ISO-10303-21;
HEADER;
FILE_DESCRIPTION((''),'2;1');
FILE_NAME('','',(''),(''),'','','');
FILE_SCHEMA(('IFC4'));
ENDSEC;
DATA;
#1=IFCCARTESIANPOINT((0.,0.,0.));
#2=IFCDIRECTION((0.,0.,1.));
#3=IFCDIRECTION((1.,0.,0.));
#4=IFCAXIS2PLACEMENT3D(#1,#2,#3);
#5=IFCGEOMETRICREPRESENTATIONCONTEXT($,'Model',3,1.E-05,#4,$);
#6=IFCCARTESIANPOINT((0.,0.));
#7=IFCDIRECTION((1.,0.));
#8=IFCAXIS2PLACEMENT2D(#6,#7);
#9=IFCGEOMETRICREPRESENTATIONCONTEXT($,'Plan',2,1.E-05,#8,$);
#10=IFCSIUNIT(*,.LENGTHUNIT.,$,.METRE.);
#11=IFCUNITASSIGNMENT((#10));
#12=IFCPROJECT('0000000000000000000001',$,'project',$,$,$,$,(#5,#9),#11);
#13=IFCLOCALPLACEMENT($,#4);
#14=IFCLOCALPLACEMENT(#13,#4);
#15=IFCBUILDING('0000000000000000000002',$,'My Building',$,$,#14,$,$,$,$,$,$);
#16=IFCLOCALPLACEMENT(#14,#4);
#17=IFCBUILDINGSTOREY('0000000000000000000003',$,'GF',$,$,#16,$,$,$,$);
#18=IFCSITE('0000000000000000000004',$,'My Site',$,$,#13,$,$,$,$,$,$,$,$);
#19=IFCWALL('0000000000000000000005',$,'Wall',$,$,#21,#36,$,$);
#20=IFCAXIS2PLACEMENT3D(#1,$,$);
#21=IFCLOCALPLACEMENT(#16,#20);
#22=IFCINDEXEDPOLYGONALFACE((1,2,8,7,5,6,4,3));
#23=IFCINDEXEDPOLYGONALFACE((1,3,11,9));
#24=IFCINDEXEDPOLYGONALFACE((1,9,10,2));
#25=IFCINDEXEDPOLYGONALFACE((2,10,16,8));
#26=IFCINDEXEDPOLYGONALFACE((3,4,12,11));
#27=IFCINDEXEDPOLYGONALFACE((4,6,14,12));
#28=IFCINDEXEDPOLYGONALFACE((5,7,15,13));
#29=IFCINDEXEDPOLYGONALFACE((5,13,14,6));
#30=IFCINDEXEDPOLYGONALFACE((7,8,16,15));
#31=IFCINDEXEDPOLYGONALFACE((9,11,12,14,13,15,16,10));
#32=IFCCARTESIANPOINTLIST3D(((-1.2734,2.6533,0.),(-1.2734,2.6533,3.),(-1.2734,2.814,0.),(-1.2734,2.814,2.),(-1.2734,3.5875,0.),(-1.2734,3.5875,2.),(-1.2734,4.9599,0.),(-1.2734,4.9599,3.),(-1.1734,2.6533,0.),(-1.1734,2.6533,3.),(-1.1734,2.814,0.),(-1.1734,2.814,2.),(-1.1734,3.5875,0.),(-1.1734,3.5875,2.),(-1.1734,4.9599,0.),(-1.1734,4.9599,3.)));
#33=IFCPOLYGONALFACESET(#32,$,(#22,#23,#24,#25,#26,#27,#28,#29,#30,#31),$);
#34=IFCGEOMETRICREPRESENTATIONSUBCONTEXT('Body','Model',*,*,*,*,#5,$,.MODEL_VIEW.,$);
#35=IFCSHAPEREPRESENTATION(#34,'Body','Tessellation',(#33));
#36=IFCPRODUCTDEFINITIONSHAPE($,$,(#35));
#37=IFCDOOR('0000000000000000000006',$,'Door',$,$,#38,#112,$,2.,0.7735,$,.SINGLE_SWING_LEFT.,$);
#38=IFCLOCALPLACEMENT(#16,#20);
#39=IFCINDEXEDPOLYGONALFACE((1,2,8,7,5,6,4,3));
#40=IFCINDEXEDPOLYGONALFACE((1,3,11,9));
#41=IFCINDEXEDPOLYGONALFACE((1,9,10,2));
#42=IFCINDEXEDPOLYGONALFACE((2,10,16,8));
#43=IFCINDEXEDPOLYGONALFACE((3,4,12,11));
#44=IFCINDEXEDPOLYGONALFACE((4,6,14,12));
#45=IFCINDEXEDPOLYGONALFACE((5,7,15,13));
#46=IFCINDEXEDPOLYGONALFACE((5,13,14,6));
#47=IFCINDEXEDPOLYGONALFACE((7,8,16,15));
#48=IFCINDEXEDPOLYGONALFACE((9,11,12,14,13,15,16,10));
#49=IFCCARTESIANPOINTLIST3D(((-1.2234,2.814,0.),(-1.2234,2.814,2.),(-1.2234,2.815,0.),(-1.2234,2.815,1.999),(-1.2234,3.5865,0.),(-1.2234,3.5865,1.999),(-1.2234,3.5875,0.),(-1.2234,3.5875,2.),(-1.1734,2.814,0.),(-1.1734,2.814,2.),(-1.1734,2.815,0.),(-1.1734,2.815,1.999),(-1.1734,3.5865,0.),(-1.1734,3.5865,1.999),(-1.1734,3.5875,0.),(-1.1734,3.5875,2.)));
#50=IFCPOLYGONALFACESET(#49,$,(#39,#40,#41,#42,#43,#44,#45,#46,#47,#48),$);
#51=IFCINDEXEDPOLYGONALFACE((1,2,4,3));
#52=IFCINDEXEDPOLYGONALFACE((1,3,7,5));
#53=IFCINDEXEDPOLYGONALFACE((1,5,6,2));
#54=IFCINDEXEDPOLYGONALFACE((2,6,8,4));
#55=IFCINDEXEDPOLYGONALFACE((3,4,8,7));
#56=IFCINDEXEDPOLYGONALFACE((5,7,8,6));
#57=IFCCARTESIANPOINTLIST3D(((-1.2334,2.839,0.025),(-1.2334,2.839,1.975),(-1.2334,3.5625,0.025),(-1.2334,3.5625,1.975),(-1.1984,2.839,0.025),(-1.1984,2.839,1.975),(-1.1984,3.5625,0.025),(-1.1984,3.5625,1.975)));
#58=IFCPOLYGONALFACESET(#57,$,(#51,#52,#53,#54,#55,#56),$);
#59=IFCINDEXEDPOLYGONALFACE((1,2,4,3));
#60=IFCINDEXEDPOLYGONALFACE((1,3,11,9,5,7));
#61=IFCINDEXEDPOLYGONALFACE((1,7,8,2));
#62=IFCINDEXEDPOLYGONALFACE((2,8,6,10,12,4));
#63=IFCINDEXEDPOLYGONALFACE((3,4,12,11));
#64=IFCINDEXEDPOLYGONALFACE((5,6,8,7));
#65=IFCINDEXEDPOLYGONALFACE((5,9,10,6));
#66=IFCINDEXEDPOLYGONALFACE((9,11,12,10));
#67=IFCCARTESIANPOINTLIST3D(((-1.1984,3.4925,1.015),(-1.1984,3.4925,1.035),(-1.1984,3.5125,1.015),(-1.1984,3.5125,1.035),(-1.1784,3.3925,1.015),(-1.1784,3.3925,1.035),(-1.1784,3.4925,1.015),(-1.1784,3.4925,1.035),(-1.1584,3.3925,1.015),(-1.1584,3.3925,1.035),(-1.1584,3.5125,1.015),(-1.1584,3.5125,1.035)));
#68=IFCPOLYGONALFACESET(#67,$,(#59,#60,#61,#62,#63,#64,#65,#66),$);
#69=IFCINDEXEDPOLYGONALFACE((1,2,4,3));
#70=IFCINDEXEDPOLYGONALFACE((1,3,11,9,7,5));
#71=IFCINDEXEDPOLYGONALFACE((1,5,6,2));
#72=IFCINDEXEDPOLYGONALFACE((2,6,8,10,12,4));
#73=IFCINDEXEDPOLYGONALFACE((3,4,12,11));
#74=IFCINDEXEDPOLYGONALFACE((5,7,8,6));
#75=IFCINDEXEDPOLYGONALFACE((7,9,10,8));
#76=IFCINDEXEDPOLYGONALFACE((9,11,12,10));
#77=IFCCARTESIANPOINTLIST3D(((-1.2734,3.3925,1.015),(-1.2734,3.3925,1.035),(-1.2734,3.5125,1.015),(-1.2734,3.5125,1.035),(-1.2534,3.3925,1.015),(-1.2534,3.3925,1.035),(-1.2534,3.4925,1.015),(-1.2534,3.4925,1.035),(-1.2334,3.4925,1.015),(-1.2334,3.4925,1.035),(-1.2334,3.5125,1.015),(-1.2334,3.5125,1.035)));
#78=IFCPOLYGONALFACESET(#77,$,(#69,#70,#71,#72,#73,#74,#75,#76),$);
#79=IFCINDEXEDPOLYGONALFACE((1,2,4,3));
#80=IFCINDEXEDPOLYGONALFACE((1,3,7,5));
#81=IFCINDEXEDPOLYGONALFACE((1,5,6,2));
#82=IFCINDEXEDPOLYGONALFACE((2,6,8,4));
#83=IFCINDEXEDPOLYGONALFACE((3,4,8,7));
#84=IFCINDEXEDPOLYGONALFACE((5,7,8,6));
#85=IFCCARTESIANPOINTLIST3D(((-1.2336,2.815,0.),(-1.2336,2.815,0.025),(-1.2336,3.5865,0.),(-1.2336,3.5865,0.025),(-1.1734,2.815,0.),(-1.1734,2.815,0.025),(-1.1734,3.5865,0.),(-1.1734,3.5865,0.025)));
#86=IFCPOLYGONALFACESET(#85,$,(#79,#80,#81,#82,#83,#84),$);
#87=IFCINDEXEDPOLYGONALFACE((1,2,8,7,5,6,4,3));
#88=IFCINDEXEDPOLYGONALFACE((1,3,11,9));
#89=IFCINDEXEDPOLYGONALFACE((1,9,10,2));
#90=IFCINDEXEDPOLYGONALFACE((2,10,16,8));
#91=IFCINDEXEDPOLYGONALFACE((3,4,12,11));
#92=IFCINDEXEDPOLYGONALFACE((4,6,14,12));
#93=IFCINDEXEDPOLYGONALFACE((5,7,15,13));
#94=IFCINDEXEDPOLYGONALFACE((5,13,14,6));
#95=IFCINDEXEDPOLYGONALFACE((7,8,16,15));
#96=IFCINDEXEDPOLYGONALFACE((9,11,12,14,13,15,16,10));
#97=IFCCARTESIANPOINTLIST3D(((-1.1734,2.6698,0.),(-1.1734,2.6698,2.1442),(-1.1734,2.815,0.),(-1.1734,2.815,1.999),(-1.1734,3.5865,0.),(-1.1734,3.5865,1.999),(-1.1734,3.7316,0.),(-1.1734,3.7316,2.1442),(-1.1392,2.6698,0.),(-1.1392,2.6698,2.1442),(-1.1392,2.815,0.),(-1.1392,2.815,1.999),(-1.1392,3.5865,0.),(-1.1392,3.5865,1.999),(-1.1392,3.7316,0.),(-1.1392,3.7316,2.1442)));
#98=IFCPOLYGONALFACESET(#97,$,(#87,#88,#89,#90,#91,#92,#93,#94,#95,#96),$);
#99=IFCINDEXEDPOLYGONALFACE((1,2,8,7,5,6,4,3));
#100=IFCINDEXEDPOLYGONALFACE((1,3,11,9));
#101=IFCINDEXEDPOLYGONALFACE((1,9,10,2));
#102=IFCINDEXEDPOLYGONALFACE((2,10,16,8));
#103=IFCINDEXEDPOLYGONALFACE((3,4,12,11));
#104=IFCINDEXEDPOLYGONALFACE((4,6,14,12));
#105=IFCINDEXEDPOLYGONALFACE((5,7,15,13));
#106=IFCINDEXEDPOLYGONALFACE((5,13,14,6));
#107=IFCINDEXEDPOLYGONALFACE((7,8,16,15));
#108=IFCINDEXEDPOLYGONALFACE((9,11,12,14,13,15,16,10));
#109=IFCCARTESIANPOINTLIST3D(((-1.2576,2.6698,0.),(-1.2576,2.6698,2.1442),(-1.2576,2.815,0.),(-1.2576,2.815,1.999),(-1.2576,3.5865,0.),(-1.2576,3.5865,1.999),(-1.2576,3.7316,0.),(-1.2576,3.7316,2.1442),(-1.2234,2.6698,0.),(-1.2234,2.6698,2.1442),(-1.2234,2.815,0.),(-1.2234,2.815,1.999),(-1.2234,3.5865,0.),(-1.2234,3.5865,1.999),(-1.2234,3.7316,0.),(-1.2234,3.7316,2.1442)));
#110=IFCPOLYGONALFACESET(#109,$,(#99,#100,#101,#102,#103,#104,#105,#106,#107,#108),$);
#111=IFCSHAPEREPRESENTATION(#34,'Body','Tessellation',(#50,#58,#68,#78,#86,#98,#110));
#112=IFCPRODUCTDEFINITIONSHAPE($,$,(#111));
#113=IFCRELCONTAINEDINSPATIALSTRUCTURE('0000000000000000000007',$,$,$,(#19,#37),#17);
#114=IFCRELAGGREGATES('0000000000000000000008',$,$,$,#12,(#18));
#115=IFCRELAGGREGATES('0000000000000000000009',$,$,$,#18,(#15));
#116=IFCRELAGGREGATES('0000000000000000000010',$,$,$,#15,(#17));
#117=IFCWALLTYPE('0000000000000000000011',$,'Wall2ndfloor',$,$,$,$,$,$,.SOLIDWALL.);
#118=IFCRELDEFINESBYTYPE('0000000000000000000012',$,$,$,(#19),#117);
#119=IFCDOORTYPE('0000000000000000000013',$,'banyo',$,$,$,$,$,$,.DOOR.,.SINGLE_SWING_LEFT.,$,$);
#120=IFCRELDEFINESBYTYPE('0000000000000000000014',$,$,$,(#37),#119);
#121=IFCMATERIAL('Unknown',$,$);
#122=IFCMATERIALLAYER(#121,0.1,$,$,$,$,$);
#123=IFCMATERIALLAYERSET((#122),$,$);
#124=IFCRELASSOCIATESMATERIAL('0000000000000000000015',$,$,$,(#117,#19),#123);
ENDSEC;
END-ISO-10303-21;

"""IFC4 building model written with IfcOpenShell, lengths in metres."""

from ifc_helpers import new_model, entity, si_unit, frame, origin_with_axes, origin_2d_with_axis, place, context, subcontext, project, spatial, line, indexed_curve, outline, extrude, shape, source, transform, mapped, material, layer, layer_set, layer_usage, type_object, type_shapes, element, fill, save


model = new_model("IFC4")

# Units and contexts
model_context = context("Model", 3, precision=1e-05, world=origin_with_axes())
plan_context = context("Plan", 2, precision=1e-05, world=origin_2d_with_axis())
body_context_1 = subcontext(model_context, "Body", "Model", "MODEL_VIEW")
body_context_2 = subcontext(plan_context, "Body", "Plan", "PLAN_VIEW")
ifc_project = project(units=[si_unit("LENGTHUNIT", "METRE")], contexts=[model_context, plan_context])

# Site, building, storey
site_placement = place(None, origin_with_axes())
site = spatial("IfcSite", under=ifc_project, at=site_placement, Name="My Site")
building_placement = place(site_placement, origin_with_axes())
building = spatial("IfcBuilding", under=site, at=building_placement, Name="My Building")
storey_placement = place(building_placement, origin_with_axes())
storey = spatial("IfcBuildingStorey", under=building, at=storey_placement, Name="GF")

# Shared definitions
ifc_material = material(Name="Unknown")

# Shared definitions
ifc_layer_1 = layer(ifc_material, 0.1)
ifc_layer_set_1 = layer_set([ifc_layer_1])
wall_type_1 = type_object("IfcWallType", Name="Wall2ndfloor", PredefinedType="SOLIDWALL", material=ifc_layer_set_1)

# Wall, opening, door
ifc_layer_usage_1 = layer_usage(ifc_layer_set_1, "AXIS2", "POSITIVE", 0.0)
wall_1_placement = place(storey_placement, frame((-1.1734, 2.6533, 0.0), z_axis=(0.0, 0.0, 1.0), x_axis=(0.0, 1.0, 0.0)))
wall_1 = element("IfcWall", 1, at=wall_1_placement, inside=storey, type_object=wall_type_1, material=ifc_layer_usage_1, Name="Wall", context=body_context_1, shape_type="SweptSolid", body=[
    extrude(outline(indexed_curve([(0.0, 0.0), (0.0, 0.1), (2.3066, 0.1), (2.3066, 0.0)], segments=[line(1, 2, 3, 4, 1)])), origin_with_axes(), (0.0, 0.0, 1.0), 3.0),
])
shared_shape_1 = source(origin_with_axes(), body_context_1, "Body", "SweptSolid", [
    extrude(outline(indexed_curve([(0.0, 0.0), (0.7735, 0.0), (0.7735, 2.0), (0.0, 2.0)], segments=[line(1, 2, 3, 4, 1)])), frame((0.0, -0.6, 0.0), z_axis=(0.0, -1.0, 0.0), x_axis=(1.0, 0.0, 0.0)), (0.0, 0.0, -1.0), 1.2),
])
opening_1_placement = place(wall_1_placement, frame((0.1607, 0.0, 0.0), z_axis=(0.0, 0.0, 1.0), x_axis=(1.0, 0.0, 0.0)))
opening_1 = element("IfcOpeningElement", 2, at=opening_1_placement, cuts=wall_1, PredefinedType="OPENING", context=body_context_1, shape_type="MappedRepresentation", body=[
    mapped(shared_shape_1, transform((0.0, 0.0, 0.0), x_axis=(1.0, 0.0, 0.0), y_axis=(0.0, 1.0, 0.0), z_axis=(0.0, 0.0, 1.0), scale=1.0)),
])
door_type_1 = type_object("IfcDoorType", Name="banyo", OperationType="SINGLE_SWING_LEFT", PredefinedType="DOOR")
shared_shape_2 = source(origin_with_axes(), body_context_1, "Body", "SweptSolid", [
    extrude(outline(indexed_curve([(0.0, 0.0), (0.0, 2.0), (0.7735, 2.0), (0.7735, 0.0), (0.7725, 0.0), (0.7725, 1.999), (0.001, 1.999), (0.001, 0.0)], segments=[line(1, 2, 3, 4, 5, 6, 7, 8, 1)])), frame((0.0, 0.0, 0.0), z_axis=(0.0, -1.0, 0.0), x_axis=(1.0, 0.0, 0.0)), (0.0, 0.0, -1.0), 0.05),
    extrude(outline(indexed_curve([(0.0, 0.0), (0.7235, 0.0), (0.7235, 0.035), (0.0, 0.035)], segments=[line(1, 2, 3, 4, 1)])), frame((0.025, 0.025, 0.025), z_axis=(0.0, 0.0, 1.0), x_axis=(1.0, 0.0, 0.0)), (0.0, 0.0, 1.0), 1.95),
    extrude(outline(indexed_curve([(0.0, 0.0), (0.0, -0.04), (-0.12, -0.04), (-0.12, -0.02), (-0.02, -0.02), (-0.02, 0.0)], segments=[line(1, 2, 3, 4, 5, 6, 1)])), frame((0.6985, 0.025, 1.015), z_axis=(0.0, 0.0, 1.0), x_axis=(1.0, 0.0, 0.0)), (0.0, 0.0, 1.0), 0.02),
    extrude(outline(indexed_curve([(0.0, 0.0), (0.0, 0.04), (-0.12, 0.04), (-0.12, 0.02), (-0.02, 0.02), (-0.02, 0.0)], segments=[line(1, 2, 3, 4, 5, 6, 1)])), frame((0.6985, 0.06, 1.015), z_axis=(0.0, 0.0, 1.0), x_axis=(1.0, 0.0, 0.0)), (0.0, 0.0, 1.0), 0.02),
    extrude(outline(indexed_curve([(0.0, 0.0), (0.7715, 0.0), (0.7715, 0.0602), (0.0, 0.0602)], segments=[line(1, 2, 3, 4, 1)])), frame((0.001, 0.0, 0.0), z_axis=(0.0, 0.0, 1.0), x_axis=(1.0, 0.0, 0.0)), (0.0, 0.0, 1.0), 0.025),
    extrude(outline(indexed_curve([(0.0, 0.0), (0.0, 2.1442), (1.0618, 2.1442), (1.0618, 0.0), (0.9167, 0.0), (0.9167, 1.999), (0.1452, 1.999), (0.1452, 0.0)], segments=[line(1, 2, 3, 4, 5, 6, 7, 8, 1)])), frame((-0.1442, -0.0342, 0.0), z_axis=(0.0, -1.0, 0.0), x_axis=(1.0, 0.0, 0.0)), (0.0, 0.0, -1.0), 0.0342),
    extrude(outline(indexed_curve([(0.0, 0.0), (0.0, 2.1442), (1.0618, 2.1442), (1.0618, 0.0), (0.9167, 0.0), (0.9167, 1.999), (0.1452, 1.999), (0.1452, 0.0)], segments=[line(1, 2, 3, 4, 5, 6, 7, 8, 1)])), frame((-0.1442, 0.05, 0.0), z_axis=(0.0, -1.0, 0.0), x_axis=(1.0, 0.0, 0.0)), (0.0, 0.0, -1.0), 0.0342),
])
shared_shape_3 = source(origin_with_axes(), body_context_2, "Body", "Curve2D", [
    entity("IfcIndexedPolyCurve", entity("IfcCartesianPointList2D", [[0.0, 0.0], [0.001, 0.0], [0.001, 0.05], [0.0, 0.05]]), [entity("IfcLineIndex", [1, 2, 3, 4, 1])]),
    entity("IfcIndexedPolyCurve", entity("IfcCartesianPointList2D", [[0.7735, 0.0], [0.7725, 0.0], [0.7725, 0.05], [0.7735, 0.05]]), [entity("IfcLineIndex", [1, 2, 3, 4, 1])]),
    entity("IfcTrimmedCurve", entity("IfcEllipse", entity("IfcAxis2Placement2D", entity("IfcCartesianPoint", [0.06, 0.05]), entity("IfcDirection", [1.0, 0.0])), 0.6885, 0.7235), [entity("IfcCartesianPoint", [0.7485, 0.05])], [entity("IfcCartesianPoint", [0.06, 0.7735])], True, "CARTESIAN"),
    entity("IfcIndexedPolyCurve", entity("IfcCartesianPointList2D", [[0.025, 0.05], [0.06, 0.05], [0.06, 0.7735], [0.025, 0.7735]]), [entity("IfcLineIndex", [1, 2, 3, 4, 1])]),
])
type_shapes(door_type_1, [shared_shape_2, shared_shape_3])
door_1_placement = place(opening_1_placement, frame((0.0, 0.0, 0.0), z_axis=(0.0, 0.0, 1.0), x_axis=(1.0, 0.0, 0.0)))
door_1 = element("IfcDoor", 3, at=door_1_placement, inside=storey, type_object=door_type_1, Name="Door", OperationType="SINGLE_SWING_LEFT", OverallHeight=2.0, OverallWidth=0.7735, shapes=[
    shape(body_context_1, "Body", "MappedRepresentation", [mapped(shared_shape_2, transform((0.0, 0.0, 0.0), x_axis=(1.0, 0.0, 0.0), y_axis=(0.0, 1.0, 0.0), z_axis=(0.0, 0.0, 1.0), scale=1.0))]),
    shape(body_context_2, "Body", "MappedRepresentation", [mapped(shared_shape_3, transform((0.0, 0.0, 0.0), x_axis=(1.0, 0.0, 0.0), y_axis=(0.0, 1.0, 0.0), z_axis=(0.0, 0.0, 1.0), scale=1.0))]),
])
fill(opening_1, door_1)

save(model, "model.ifc")
